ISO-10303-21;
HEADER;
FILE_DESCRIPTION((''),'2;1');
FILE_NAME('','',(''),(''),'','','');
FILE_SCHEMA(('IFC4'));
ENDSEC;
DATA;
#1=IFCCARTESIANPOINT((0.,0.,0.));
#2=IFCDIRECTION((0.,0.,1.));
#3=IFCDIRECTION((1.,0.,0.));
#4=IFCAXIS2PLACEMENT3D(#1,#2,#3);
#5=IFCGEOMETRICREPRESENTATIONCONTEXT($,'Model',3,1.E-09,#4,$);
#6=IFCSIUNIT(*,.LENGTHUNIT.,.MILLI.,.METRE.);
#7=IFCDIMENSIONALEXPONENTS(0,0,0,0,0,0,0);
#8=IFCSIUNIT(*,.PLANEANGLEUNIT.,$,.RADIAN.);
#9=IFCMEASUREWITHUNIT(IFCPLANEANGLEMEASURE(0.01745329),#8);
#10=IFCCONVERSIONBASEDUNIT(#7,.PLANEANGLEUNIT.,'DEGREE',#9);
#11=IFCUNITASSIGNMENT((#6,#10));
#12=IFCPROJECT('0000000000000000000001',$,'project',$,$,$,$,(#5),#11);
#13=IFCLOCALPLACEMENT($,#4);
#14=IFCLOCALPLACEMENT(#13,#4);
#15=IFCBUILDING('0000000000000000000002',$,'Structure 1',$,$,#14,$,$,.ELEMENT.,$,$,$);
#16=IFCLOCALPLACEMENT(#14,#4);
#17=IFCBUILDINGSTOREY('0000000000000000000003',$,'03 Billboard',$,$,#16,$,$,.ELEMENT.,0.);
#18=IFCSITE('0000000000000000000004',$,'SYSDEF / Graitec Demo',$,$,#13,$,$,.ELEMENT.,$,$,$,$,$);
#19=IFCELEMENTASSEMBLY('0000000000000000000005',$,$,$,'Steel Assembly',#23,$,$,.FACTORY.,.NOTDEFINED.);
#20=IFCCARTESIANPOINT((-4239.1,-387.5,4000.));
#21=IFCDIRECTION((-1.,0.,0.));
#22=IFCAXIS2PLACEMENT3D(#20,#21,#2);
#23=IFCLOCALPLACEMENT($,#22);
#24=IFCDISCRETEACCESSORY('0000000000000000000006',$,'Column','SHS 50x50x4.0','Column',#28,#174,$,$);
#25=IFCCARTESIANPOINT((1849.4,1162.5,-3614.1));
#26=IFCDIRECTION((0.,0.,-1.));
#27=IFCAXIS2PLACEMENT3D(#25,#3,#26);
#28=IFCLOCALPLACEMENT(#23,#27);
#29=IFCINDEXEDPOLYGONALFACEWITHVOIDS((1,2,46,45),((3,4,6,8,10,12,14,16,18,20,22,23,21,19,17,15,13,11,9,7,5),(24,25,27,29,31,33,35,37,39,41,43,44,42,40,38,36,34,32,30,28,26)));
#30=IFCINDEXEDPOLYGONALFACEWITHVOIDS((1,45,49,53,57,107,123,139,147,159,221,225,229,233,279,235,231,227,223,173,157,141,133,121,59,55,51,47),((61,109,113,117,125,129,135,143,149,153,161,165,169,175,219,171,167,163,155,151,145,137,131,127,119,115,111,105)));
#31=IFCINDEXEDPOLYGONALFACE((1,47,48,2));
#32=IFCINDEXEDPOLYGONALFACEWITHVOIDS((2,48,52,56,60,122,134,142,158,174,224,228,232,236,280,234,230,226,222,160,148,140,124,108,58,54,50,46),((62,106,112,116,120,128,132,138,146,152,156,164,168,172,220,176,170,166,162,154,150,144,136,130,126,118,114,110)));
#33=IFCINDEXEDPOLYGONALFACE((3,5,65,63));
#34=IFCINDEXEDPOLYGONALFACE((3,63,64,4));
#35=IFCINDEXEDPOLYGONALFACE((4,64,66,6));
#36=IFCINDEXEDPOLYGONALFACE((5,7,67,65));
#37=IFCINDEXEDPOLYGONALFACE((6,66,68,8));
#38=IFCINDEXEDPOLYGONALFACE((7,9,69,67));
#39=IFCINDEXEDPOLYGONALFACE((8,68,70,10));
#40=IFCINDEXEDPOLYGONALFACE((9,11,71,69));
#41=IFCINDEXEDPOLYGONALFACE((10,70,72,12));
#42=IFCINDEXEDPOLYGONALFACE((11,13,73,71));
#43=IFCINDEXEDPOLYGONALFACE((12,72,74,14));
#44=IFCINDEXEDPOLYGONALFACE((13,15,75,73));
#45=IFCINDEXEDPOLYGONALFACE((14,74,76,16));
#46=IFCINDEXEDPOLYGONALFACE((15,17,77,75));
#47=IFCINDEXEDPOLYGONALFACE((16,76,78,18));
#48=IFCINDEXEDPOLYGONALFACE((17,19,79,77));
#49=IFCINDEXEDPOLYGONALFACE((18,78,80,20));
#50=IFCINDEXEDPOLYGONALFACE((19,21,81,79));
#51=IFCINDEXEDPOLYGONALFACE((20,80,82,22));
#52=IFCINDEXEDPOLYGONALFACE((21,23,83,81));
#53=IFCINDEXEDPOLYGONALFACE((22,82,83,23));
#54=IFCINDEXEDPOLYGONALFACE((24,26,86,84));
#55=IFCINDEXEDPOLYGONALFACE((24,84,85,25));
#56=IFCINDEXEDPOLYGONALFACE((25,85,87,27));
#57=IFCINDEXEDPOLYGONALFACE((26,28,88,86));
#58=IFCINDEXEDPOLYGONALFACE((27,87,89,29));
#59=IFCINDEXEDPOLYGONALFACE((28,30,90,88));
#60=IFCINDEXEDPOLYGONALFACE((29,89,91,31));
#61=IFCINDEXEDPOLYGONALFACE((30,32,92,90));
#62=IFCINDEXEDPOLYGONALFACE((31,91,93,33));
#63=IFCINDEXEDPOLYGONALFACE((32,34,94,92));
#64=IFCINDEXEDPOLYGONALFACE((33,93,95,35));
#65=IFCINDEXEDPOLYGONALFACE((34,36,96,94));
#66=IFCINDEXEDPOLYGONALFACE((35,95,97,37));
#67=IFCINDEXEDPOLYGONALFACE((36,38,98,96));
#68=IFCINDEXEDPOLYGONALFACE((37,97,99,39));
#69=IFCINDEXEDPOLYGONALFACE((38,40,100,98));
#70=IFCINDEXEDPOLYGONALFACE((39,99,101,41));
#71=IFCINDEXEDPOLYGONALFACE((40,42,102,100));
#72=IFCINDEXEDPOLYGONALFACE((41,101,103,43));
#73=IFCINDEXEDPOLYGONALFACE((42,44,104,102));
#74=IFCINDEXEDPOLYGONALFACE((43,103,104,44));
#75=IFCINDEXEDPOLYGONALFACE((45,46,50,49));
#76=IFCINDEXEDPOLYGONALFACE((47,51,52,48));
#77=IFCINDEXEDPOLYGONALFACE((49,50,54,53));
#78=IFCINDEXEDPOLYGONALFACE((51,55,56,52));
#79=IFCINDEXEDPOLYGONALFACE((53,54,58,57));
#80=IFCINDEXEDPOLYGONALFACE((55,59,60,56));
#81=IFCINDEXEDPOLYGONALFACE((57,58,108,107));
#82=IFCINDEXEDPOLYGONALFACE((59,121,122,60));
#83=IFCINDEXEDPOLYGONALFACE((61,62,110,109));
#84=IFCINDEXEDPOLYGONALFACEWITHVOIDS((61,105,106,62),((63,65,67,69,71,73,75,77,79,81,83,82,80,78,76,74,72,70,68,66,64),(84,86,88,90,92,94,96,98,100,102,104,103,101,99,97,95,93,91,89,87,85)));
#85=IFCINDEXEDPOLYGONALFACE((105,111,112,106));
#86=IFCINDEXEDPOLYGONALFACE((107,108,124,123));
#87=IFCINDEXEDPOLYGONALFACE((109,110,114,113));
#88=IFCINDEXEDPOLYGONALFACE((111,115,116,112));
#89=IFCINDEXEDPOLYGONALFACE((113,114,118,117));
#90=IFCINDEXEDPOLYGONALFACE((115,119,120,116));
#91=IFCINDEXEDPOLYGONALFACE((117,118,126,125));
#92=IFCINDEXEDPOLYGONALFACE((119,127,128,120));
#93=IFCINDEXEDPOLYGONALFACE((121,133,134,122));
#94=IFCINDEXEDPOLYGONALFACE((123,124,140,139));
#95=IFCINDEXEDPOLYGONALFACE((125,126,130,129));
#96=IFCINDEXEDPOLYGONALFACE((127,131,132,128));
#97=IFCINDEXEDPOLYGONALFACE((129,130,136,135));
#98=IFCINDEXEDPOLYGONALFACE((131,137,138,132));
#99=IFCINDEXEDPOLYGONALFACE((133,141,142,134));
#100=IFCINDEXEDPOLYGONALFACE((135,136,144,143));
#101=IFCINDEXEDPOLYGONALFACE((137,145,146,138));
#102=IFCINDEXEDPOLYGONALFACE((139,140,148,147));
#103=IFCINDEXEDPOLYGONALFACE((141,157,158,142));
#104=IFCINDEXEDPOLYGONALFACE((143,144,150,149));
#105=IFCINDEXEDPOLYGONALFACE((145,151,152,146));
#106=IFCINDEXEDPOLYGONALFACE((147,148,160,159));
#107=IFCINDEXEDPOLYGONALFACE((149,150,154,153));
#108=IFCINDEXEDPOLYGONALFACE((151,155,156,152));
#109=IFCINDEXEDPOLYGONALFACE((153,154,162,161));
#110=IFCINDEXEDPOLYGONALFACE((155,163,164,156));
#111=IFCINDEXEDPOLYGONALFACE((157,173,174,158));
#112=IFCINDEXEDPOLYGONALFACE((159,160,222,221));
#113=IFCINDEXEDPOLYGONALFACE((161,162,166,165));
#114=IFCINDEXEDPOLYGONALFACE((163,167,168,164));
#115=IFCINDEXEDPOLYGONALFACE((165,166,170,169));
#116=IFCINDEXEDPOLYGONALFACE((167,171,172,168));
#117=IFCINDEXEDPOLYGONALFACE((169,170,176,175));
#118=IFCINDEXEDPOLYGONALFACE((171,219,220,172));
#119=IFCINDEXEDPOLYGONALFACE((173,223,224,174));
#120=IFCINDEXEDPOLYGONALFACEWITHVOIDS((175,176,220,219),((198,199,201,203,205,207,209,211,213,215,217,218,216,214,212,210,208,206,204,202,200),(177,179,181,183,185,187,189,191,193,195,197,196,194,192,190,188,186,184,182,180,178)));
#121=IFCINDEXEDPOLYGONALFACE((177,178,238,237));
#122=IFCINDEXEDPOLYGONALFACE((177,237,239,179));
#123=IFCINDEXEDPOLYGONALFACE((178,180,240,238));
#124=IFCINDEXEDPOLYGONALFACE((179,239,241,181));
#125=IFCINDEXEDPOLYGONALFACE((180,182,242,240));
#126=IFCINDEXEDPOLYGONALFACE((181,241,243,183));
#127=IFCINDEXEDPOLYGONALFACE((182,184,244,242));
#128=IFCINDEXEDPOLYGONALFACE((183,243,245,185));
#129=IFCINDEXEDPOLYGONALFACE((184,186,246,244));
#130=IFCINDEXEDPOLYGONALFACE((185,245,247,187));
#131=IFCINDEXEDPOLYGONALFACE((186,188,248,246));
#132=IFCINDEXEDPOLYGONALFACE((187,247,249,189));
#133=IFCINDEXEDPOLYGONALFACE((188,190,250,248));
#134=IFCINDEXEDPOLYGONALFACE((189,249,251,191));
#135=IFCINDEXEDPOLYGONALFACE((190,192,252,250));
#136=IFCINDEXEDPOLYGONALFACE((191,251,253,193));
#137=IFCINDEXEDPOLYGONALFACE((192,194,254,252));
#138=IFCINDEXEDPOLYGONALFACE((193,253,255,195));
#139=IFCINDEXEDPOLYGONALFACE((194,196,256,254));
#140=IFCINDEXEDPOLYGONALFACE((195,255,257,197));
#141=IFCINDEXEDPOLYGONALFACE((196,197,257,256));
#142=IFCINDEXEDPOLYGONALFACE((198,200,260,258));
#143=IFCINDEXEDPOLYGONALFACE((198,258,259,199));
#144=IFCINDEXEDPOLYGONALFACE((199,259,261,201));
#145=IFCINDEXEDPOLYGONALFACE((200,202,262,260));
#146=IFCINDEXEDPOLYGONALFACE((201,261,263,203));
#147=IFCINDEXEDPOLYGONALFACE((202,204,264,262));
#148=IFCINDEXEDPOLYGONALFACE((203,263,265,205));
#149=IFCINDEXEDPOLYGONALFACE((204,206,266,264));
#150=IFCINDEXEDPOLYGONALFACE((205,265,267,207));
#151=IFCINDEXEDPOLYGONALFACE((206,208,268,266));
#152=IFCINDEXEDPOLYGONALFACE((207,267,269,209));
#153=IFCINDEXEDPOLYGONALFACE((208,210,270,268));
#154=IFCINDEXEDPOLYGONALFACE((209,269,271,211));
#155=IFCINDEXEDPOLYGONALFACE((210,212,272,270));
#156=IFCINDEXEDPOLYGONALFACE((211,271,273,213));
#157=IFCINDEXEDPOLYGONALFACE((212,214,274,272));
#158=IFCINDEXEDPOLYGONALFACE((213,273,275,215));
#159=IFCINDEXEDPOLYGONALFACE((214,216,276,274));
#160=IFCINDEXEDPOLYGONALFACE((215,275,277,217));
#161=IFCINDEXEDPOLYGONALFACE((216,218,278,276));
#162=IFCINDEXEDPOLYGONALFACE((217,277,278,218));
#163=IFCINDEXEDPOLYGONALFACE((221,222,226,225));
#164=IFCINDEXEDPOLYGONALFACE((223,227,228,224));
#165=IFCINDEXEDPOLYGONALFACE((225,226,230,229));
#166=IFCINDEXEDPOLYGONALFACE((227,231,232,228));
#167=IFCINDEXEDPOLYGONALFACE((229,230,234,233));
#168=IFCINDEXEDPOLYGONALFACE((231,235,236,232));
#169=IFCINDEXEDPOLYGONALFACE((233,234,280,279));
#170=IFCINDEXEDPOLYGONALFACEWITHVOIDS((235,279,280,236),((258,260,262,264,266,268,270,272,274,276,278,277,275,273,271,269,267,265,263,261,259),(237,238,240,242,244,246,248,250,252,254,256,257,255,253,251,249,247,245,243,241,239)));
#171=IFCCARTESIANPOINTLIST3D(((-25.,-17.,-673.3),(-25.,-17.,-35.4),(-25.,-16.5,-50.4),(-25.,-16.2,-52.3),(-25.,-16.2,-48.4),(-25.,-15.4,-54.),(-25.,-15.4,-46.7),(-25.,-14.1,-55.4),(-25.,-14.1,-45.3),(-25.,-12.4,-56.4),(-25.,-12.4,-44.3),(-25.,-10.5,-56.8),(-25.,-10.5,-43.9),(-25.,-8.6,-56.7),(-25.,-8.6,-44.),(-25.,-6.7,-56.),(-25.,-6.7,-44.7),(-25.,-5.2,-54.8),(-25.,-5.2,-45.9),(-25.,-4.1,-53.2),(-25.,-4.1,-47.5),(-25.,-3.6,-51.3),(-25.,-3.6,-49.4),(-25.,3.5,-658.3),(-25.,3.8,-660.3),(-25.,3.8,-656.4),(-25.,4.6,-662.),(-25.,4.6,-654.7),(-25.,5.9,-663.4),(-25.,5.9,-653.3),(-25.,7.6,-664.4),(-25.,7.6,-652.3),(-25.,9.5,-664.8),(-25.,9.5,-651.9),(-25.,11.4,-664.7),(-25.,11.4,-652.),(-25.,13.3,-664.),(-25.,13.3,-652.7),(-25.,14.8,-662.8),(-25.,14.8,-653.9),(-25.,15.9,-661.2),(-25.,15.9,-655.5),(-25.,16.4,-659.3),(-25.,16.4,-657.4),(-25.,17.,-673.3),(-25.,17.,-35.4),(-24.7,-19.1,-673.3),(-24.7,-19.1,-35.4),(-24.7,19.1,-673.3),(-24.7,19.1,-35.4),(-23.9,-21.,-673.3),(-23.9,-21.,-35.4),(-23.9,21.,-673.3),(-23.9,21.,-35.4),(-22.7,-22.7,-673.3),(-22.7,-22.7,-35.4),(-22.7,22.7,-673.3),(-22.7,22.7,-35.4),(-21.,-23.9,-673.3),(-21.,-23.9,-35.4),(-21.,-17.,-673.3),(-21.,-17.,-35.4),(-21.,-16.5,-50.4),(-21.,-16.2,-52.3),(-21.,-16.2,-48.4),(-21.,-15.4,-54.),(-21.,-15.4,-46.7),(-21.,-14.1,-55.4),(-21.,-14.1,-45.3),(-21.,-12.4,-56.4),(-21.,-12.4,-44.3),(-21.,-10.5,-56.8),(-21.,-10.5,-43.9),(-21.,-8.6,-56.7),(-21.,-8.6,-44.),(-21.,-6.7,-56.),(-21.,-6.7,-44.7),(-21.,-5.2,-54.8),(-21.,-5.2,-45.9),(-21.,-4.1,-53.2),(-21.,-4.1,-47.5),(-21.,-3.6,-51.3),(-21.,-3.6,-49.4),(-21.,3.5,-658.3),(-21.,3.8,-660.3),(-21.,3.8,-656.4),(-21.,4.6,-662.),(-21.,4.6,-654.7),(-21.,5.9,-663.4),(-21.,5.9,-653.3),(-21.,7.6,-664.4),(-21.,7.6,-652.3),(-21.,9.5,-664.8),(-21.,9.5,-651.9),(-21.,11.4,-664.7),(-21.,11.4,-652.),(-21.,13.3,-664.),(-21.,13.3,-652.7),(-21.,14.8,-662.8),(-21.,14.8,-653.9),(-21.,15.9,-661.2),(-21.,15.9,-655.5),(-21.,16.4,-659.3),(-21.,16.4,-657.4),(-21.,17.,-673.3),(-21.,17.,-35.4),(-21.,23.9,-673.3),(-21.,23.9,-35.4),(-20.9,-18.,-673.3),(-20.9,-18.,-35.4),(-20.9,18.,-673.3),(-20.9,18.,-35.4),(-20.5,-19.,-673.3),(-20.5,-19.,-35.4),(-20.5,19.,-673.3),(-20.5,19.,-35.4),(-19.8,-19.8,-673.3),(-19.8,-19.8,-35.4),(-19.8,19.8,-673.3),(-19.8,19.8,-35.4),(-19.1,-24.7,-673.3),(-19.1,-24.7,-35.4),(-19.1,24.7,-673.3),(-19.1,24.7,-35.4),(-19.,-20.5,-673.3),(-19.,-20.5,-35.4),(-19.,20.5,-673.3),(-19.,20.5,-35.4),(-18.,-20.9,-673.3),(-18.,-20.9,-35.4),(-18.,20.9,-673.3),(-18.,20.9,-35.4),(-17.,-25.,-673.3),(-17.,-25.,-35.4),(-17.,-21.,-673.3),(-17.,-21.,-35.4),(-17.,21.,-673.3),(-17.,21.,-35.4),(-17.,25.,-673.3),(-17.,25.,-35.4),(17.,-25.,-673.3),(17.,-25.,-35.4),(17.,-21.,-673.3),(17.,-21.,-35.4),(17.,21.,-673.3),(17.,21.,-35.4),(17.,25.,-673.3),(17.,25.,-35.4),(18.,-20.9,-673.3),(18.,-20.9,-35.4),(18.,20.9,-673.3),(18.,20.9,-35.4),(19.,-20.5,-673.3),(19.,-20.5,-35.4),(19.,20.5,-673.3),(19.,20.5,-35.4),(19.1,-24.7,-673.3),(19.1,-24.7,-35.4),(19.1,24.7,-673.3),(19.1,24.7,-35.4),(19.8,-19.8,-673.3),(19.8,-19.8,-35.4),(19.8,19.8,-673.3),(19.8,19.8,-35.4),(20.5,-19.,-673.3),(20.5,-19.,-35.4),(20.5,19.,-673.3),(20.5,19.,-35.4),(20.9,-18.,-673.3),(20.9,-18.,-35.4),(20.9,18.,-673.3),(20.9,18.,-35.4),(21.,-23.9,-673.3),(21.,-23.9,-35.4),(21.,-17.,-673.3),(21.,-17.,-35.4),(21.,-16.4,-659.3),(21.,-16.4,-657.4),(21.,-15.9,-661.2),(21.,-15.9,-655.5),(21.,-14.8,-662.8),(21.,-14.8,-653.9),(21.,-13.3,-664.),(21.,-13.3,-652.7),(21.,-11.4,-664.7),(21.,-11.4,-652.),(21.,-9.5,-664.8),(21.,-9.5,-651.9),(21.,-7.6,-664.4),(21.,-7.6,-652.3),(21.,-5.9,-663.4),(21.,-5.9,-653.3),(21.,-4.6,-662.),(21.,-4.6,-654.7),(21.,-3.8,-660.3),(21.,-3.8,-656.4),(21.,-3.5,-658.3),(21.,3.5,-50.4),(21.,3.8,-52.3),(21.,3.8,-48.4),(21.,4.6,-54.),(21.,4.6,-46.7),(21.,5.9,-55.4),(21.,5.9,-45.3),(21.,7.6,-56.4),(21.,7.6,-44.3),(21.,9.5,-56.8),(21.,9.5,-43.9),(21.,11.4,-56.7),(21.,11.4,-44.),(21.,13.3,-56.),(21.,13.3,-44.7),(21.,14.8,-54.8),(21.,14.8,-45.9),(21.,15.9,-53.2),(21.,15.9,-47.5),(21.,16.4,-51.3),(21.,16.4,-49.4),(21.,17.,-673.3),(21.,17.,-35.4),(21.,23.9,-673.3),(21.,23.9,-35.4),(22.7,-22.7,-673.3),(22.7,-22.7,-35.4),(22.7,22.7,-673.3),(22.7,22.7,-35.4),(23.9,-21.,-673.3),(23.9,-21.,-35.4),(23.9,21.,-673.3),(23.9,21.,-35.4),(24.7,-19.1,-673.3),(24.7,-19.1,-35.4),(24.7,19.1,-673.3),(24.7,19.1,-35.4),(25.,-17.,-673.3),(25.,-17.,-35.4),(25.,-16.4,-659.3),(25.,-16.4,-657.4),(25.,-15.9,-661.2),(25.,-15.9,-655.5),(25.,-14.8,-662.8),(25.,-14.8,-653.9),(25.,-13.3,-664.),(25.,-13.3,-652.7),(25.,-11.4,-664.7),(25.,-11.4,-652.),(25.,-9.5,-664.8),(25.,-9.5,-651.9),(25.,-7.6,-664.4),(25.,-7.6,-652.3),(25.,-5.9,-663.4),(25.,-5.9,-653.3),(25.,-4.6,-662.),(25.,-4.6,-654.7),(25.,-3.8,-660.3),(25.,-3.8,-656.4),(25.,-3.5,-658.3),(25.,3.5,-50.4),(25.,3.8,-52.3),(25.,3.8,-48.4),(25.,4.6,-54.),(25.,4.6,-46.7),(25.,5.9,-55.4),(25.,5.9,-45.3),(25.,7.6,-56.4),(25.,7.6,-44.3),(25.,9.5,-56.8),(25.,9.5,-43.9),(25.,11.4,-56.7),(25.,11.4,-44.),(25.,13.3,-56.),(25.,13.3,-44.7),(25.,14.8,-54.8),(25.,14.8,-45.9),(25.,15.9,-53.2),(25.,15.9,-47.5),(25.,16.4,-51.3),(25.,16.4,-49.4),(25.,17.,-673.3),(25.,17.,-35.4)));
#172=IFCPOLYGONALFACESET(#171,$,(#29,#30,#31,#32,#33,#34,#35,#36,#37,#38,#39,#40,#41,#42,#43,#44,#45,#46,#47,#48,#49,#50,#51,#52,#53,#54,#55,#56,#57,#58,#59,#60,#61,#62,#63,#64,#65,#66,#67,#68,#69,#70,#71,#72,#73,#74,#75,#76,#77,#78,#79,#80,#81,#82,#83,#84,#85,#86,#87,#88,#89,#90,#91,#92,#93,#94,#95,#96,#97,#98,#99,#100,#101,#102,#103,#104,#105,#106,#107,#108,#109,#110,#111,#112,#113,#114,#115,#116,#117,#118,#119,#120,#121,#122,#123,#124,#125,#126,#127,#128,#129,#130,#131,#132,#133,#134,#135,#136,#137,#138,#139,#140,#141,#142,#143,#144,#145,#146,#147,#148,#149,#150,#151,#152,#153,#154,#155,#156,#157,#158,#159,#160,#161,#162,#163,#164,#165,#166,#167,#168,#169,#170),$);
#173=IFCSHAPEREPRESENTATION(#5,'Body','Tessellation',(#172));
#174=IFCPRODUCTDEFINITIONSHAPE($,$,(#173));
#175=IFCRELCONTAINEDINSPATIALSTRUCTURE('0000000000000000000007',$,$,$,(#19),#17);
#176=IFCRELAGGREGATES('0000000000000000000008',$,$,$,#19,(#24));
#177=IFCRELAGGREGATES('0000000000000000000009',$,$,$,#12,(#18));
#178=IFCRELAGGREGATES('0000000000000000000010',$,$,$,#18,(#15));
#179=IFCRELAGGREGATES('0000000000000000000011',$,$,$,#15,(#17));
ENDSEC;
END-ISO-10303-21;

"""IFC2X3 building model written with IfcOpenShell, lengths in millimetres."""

from ifc_helpers import new_model, entity, si_unit, converted_unit, frame, frame_2d, origin, origin_with_axes, origin_2d, origin_2d_with_axis, place, context, project, spatial, hollow_rectangle, circle, extrude, clip, halfspace, element, aggregate, save


model = new_model("IFC2X3")

# Units and contexts
model_context = context("Model", 3, precision=1e-09, world=origin_with_axes())
ifc_project = project(units=[si_unit("LENGTHUNIT", "METRE", prefix="MILLI"), converted_unit("PLANEANGLEUNIT", "DEGREE", entity("IfcPlaneAngleMeasure", 0.01745329), si_unit("PLANEANGLEUNIT", "RADIAN"), dimensions=[0, 0, 0, 0, 0, 0, 0])], contexts=[model_context])

# Site, building, storey
site_placement = place(None, origin_with_axes())
site = spatial("IfcSite", under=ifc_project, at=site_placement, Name="SYSDEF / Graitec Demo", CompositionType="ELEMENT")
building_placement = place(site_placement, origin_with_axes())
building = spatial("IfcBuilding", under=site, at=building_placement, Name="Structure 1", CompositionType="ELEMENT")
storey_placement = place(building_placement, origin_with_axes())
storey = spatial("IfcBuildingStorey", under=building, at=storey_placement, Name="03 Billboard", CompositionType="ELEMENT", Elevation=0.0)

# Element assembly, discrete accessory, openings
assembly_1_placement = place(None, frame((-4239.1, -387.5, 4000.0), z_axis=(-1.0, 0.0, 0.0), x_axis=(0.0, 0.0, 1.0)))
assembly_1 = element("IfcElementAssembly", 1, at=assembly_1_placement, inside=storey, ObjectType="Steel Assembly", AssemblyPlace="FACTORY", PredefinedType="NOTDEFINED")
discrete_accessory_1_placement = place(assembly_1_placement, frame((1849.4, 1162.5, -3614.1), z_axis=(1.0, 0.0, 0.0), x_axis=(0.0, 0.0, -1.0)))
discrete_accessory_1 = element("IfcDiscreteAccessory", 2, at=discrete_accessory_1_placement, Name="Column", Description="SHS 50x50x4.0", ObjectType="Column", context=model_context, shape_type="Clipping", body=[
    clip(clip(extrude(hollow_rectangle(XDim=50.0, YDim=50.0, WallThickness=4.0, InnerFilletRadius=4.0, OuterFilletRadius=8.0, at=origin_2d()), origin(), (0.0, 0.0, -1.0), 733.7), halfspace(frame((625.0, -775.0, -673.3), z_axis=(0.0, 0.0, 1.0), x_axis=(1.0, 0.0, 0.0)), True)), halfspace(frame((625.0, -775.0, -35.4), z_axis=(0.0, 0.0, -1.0), x_axis=(-1.0, 0.0, 0.0)), True)),
])
opening_1_placement = place(discrete_accessory_1_placement, frame((-25.5, 16.5, -658.3), z_axis=(-1.0, 0.0, 0.0), x_axis=(0.0, -1.0, 0.0)))
element("IfcOpeningElement", 3, at=opening_1_placement, cuts=discrete_accessory_1, ObjectType="Opening", context=model_context, shape_type="SweptSolid", body=[
    extrude(circle(Radius=6.5, at=frame_2d((6.5, 0.0), x_axis=(1.0, 0.0))), origin(), (0.0, 0.0, -1.0), 5.0),
])
opening_2_placement = place(discrete_accessory_1_placement, frame((20.5, -10.0, -658.3), z_axis=(1.0, 0.0, 0.0), x_axis=(0.0, 1.0, 0.0)))
element("IfcOpeningElement", 4, at=opening_2_placement, cuts=discrete_accessory_1, ObjectType="Opening", context=model_context, shape_type="SweptSolid", body=[
    extrude(circle(Radius=6.5, at=origin_2d_with_axis()), origin(), (0.0, 0.0, 1.0), 5.0),
])
opening_3_placement = place(discrete_accessory_1_placement, frame((-25.5, -16.5, -50.4), z_axis=(-1.0, 0.0, 0.0), x_axis=(0.0, -1.0, 0.0)))
element("IfcOpeningElement", 5, at=opening_3_placement, cuts=discrete_accessory_1, ObjectType="Opening", context=model_context, shape_type="SweptSolid", body=[
    extrude(circle(Radius=6.5, at=frame_2d((-6.5, 0.0), x_axis=(1.0, 0.0))), origin(), (0.0, 0.0, -1.0), 5.0),
])
opening_4_placement = place(discrete_accessory_1_placement, frame((20.5, 10.0, -50.4), z_axis=(1.0, 0.0, 0.0), x_axis=(0.0, -1.0, 0.0)))
element("IfcOpeningElement", 6, at=opening_4_placement, cuts=discrete_accessory_1, ObjectType="Opening", context=model_context, shape_type="SweptSolid", body=[
    extrude(circle(Radius=6.5, at=origin_2d_with_axis()), origin(), (0.0, 0.0, 1.0), 5.0),
])
aggregate(assembly_1, [discrete_accessory_1])

save(model, "model.ifc")
